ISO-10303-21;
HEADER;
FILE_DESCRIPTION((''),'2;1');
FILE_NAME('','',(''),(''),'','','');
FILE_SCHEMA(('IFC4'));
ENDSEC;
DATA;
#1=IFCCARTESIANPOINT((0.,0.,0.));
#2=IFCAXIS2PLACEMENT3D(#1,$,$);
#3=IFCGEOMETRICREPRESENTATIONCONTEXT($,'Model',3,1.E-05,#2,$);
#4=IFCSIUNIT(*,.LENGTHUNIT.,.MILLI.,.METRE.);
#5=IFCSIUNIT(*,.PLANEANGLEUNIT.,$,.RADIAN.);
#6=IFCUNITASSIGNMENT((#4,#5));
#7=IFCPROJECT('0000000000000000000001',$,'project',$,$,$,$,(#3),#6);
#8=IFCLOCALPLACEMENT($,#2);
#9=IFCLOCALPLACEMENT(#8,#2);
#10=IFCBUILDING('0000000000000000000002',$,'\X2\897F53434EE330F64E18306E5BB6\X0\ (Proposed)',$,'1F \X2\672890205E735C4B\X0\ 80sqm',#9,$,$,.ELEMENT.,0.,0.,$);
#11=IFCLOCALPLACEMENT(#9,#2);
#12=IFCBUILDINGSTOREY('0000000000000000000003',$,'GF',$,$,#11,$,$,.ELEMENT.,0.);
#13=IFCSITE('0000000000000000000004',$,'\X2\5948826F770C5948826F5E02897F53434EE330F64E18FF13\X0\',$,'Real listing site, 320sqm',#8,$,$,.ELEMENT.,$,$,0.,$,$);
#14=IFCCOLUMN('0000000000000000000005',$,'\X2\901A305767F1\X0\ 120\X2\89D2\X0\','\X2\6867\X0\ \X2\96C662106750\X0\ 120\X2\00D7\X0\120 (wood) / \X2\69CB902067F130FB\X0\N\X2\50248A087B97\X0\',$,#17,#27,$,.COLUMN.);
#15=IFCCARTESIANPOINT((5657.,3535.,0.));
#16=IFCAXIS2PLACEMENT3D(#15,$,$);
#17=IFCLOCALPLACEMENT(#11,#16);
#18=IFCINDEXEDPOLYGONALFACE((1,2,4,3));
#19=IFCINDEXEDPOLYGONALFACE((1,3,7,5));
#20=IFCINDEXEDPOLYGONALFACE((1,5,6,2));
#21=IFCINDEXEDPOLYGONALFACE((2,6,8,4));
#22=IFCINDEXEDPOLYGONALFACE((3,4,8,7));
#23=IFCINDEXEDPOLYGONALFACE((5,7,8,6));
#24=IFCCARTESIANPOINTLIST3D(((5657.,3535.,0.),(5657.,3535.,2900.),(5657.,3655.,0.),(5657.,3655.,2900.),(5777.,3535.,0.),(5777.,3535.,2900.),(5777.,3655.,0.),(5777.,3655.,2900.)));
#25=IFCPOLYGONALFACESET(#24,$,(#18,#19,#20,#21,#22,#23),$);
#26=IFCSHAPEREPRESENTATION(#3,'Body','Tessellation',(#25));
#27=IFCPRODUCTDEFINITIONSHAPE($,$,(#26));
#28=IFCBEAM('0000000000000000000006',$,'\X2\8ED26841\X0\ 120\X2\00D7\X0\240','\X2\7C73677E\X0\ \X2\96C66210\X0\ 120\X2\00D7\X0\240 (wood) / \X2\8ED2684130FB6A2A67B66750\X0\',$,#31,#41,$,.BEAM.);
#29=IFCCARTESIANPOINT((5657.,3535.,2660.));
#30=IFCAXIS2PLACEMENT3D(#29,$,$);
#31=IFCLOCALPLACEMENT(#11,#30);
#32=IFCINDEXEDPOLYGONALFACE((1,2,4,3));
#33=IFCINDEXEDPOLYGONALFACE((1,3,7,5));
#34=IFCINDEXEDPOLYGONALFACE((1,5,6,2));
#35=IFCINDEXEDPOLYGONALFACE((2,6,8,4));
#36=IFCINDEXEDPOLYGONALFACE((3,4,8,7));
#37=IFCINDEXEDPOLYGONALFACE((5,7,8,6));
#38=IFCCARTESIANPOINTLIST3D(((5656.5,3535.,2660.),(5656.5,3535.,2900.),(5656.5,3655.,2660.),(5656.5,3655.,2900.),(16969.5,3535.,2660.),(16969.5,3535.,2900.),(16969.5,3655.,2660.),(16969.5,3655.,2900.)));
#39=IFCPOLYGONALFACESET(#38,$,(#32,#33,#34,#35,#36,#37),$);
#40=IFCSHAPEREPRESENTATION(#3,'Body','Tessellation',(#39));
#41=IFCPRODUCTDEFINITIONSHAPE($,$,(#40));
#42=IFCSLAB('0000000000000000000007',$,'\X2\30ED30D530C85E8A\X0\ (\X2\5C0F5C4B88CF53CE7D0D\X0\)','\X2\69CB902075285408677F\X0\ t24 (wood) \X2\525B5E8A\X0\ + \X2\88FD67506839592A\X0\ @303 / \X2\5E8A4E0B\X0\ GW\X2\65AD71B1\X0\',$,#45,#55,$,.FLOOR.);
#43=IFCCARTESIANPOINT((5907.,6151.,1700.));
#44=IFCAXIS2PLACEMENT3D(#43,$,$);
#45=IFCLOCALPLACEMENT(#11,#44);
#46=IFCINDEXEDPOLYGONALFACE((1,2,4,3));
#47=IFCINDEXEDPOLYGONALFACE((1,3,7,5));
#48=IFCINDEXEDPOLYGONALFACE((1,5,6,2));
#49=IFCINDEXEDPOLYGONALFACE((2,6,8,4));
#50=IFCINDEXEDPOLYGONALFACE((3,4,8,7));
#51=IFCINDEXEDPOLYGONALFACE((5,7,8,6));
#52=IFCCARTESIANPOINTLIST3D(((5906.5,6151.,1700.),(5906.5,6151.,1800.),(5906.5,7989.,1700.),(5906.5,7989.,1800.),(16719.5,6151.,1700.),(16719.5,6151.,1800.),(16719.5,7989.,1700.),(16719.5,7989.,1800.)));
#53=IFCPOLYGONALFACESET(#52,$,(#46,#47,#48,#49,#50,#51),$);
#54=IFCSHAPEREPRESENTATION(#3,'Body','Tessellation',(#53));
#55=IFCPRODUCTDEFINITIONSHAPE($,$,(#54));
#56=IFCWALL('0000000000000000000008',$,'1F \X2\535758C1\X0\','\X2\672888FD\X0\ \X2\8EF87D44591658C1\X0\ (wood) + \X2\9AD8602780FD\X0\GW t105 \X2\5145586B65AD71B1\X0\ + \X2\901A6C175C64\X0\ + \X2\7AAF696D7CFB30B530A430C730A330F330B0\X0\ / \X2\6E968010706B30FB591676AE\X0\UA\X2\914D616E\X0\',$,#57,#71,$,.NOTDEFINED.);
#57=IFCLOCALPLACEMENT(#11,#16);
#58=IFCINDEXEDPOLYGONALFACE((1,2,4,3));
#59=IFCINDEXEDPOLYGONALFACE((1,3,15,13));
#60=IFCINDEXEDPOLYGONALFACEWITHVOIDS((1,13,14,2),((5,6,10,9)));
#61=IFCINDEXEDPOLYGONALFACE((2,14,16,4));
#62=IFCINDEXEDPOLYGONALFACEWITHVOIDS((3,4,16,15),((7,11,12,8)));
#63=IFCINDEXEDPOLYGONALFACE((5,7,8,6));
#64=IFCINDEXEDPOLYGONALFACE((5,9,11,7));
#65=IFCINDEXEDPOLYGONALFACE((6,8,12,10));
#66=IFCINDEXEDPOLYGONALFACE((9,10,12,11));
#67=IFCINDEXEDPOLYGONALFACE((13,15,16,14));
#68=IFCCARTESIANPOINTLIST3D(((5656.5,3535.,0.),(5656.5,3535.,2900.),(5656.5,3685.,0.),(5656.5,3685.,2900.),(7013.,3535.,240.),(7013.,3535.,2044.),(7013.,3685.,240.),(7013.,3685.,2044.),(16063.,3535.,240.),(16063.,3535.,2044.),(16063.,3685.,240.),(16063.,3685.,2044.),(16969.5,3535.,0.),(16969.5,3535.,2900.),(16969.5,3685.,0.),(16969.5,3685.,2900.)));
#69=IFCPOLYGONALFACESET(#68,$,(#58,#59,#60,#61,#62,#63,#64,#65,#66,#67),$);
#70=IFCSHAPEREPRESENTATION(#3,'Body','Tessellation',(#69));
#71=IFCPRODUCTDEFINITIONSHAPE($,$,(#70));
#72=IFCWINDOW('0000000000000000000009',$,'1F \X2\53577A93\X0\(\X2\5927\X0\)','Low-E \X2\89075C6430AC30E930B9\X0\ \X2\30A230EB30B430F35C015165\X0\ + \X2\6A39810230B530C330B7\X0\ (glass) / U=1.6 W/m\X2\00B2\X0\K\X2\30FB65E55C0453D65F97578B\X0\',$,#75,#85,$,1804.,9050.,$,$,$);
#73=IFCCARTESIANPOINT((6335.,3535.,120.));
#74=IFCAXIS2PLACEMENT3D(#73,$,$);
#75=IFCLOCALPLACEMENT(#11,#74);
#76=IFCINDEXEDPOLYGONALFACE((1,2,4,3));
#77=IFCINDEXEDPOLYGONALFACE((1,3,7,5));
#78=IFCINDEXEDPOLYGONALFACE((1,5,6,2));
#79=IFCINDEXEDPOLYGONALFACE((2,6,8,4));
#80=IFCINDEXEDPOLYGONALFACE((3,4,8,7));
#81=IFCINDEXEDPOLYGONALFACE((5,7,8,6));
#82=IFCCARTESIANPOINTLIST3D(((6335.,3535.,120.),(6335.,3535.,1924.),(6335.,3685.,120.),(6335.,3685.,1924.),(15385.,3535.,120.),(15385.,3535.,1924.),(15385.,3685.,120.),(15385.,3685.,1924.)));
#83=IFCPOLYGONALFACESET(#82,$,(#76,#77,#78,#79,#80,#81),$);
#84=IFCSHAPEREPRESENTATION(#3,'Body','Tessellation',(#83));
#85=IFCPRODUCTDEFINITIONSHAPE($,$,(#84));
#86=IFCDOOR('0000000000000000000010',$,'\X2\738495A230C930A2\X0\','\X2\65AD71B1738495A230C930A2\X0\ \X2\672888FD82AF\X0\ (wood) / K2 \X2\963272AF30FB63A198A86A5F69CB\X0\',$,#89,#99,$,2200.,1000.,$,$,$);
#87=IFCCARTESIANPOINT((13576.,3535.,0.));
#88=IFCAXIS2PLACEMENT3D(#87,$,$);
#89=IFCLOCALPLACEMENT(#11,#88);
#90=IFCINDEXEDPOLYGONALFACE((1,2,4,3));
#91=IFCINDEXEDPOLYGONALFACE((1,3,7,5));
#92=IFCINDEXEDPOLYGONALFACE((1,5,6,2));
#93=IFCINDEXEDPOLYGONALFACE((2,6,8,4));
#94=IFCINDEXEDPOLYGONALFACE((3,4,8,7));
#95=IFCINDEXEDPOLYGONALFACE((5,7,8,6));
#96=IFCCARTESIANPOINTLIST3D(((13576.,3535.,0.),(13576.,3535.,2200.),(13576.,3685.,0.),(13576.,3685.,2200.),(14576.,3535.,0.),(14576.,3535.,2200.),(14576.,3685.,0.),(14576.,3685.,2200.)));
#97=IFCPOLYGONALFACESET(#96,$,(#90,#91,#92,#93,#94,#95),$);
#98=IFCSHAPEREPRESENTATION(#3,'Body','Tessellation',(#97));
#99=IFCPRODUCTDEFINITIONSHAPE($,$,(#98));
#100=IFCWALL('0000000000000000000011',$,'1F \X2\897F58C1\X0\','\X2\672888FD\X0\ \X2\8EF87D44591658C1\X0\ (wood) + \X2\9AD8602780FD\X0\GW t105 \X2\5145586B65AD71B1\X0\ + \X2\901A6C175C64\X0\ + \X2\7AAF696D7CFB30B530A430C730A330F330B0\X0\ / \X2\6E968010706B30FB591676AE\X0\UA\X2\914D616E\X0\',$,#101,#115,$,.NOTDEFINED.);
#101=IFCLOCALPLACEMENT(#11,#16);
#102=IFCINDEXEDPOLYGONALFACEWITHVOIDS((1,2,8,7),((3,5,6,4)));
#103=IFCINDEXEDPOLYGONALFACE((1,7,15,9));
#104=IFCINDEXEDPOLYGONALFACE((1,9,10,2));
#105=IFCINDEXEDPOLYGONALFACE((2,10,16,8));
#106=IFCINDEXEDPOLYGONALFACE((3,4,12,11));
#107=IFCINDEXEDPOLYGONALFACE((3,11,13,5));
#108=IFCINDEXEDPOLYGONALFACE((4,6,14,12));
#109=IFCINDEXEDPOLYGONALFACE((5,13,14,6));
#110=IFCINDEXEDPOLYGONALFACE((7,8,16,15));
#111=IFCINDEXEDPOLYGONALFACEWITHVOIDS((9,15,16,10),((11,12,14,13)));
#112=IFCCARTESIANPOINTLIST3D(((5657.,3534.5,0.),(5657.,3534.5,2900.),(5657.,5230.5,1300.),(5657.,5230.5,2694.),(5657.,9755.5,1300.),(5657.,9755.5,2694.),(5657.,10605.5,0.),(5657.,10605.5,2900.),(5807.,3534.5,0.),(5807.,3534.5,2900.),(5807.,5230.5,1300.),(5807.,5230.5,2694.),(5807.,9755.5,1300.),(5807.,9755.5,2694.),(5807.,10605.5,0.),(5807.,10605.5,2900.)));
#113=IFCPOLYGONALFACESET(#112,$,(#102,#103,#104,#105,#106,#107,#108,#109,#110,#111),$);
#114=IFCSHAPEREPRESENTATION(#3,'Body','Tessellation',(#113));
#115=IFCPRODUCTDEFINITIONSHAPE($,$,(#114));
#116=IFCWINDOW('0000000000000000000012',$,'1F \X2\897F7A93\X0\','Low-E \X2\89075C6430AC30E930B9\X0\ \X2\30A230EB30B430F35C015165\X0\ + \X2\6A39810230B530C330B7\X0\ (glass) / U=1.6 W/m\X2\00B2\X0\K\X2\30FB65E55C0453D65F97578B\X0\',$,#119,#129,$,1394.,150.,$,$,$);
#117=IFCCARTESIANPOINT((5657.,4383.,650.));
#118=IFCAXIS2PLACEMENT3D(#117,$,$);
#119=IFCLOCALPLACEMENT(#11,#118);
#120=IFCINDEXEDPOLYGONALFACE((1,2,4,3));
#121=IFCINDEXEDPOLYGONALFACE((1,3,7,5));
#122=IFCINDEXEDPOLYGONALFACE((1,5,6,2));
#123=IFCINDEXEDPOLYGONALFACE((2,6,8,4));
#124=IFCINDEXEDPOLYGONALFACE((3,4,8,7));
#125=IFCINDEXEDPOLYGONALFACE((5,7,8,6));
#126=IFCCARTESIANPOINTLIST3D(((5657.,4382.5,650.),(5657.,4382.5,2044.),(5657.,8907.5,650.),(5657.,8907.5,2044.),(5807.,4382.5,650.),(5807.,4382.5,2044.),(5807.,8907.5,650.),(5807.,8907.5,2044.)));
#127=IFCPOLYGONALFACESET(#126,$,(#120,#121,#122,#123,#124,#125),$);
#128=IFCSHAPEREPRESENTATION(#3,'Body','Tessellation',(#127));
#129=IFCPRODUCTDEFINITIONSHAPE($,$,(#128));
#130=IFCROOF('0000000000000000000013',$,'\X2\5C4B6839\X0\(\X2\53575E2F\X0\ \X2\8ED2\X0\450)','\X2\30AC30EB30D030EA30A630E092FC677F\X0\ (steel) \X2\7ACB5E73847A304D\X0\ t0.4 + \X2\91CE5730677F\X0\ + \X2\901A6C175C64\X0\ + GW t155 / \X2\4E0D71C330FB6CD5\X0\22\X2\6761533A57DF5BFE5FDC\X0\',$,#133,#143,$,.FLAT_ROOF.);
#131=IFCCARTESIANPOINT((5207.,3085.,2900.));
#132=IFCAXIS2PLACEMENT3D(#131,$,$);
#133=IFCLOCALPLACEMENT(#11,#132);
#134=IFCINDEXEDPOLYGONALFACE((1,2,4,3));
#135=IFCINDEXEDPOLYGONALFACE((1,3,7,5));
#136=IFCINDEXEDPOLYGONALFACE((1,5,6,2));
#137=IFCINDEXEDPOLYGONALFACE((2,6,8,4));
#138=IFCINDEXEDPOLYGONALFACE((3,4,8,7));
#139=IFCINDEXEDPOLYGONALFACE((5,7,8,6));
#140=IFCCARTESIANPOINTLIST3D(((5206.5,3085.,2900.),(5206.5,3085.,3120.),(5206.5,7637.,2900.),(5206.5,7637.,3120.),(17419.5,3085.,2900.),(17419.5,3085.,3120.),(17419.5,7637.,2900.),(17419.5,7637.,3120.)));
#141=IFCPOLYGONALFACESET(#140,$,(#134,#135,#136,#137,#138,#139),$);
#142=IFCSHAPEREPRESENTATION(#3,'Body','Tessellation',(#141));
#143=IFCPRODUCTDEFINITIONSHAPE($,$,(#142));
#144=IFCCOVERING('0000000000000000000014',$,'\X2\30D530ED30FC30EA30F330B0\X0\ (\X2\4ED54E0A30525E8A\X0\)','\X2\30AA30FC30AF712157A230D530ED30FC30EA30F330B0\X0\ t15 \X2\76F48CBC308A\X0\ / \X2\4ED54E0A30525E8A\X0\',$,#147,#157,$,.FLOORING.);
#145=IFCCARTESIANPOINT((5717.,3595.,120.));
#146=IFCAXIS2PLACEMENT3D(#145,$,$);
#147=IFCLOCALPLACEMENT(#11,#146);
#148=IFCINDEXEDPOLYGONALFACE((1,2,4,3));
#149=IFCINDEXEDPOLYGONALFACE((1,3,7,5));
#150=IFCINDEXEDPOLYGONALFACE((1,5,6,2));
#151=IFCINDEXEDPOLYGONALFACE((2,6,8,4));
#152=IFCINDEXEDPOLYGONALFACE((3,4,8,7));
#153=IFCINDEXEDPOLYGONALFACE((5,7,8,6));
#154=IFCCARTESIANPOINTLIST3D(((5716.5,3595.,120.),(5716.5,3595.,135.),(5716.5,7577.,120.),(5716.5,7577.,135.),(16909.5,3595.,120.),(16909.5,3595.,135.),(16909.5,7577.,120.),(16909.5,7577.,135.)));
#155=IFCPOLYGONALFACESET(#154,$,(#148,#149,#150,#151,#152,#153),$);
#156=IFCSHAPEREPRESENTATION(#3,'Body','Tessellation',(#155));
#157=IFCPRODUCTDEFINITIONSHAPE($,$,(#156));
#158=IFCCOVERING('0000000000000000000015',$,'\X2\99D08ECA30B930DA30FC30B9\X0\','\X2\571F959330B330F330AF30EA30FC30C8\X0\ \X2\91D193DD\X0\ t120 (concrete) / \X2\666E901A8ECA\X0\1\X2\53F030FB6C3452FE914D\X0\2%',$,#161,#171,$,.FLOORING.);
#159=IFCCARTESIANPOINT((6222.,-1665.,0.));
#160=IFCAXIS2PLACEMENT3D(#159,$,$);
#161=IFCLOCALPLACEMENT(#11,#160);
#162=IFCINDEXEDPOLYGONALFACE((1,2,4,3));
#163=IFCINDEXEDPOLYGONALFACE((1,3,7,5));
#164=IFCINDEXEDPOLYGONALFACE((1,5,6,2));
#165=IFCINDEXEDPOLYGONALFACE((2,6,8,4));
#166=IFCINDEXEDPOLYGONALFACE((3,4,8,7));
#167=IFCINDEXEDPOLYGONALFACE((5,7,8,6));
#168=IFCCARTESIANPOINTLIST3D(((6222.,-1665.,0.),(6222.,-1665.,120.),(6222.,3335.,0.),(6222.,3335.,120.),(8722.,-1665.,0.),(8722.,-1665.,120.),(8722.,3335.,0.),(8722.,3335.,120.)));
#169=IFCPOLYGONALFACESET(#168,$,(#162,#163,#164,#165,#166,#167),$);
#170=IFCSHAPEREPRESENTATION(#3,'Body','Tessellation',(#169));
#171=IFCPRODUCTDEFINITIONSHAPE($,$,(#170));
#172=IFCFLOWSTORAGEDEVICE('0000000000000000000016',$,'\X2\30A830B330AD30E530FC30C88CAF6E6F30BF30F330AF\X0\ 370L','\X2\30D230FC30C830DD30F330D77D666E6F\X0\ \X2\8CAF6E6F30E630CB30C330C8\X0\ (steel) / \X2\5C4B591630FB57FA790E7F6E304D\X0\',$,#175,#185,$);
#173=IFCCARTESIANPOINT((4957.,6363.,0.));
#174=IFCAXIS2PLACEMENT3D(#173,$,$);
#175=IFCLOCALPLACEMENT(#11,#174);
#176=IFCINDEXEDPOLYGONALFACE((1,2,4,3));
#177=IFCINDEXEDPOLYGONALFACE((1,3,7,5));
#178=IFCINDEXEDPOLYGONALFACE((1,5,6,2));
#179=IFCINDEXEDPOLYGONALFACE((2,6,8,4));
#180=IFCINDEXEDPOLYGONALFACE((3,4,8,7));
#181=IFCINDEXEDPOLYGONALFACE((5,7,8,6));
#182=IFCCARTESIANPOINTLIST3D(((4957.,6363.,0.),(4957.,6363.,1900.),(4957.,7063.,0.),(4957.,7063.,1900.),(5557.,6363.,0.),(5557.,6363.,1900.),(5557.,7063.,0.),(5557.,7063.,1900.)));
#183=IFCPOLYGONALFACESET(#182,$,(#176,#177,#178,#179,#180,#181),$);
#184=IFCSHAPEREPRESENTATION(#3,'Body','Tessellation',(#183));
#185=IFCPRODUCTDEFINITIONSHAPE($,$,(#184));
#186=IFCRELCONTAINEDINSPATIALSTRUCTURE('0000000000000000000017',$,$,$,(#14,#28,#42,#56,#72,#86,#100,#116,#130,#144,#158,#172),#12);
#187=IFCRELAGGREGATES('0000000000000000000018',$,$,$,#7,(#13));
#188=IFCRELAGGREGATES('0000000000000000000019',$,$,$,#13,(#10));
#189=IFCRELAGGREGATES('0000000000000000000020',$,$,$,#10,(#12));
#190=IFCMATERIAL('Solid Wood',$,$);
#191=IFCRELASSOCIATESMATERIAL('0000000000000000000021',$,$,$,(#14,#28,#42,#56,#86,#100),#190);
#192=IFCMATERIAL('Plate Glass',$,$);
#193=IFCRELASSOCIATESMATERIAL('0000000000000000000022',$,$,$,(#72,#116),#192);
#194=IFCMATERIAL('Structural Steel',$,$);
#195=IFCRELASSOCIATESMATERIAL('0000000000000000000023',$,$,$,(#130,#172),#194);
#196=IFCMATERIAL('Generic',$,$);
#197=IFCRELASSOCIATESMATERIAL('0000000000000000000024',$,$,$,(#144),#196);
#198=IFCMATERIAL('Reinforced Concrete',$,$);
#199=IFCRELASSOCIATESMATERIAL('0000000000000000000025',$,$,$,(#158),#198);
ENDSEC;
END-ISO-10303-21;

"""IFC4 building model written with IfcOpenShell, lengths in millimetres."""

from ifc_helpers import new_model, si_unit, frame, frame_2d, origin, place, context, project, spatial, rectangle, extrude, material, element, fill, save


model = new_model("IFC4")

# Units and contexts
model_context = context("Model", 3, precision=1e-05, world=origin())
ifc_project = project(units=[si_unit("LENGTHUNIT", "METRE", prefix="MILLI"), si_unit("PLANEANGLEUNIT", "RADIAN")], contexts=[model_context])

# Site, building, storey
site_placement = place(None, origin())
site = spatial("IfcSite", under=ifc_project, at=site_placement, Name="奈良県奈良市西千代ヶ丘３", ObjectType="Real listing site, 320sqm", CompositionType="ELEMENT", RefElevation=0.0)
building_placement = place(site_placement, origin())
building = spatial("IfcBuilding", under=site, at=building_placement, Name="西千代ヶ丘の家 (Proposed)", ObjectType="1F 木造平屋 80sqm", CompositionType="ELEMENT", ElevationOfRefHeight=0.0, ElevationOfTerrain=0.0)
storey_placement = place(building_placement, origin())
storey = spatial("IfcBuildingStorey", under=building, at=storey_placement, Name="GF", CompositionType="ELEMENT", Elevation=0.0)

# Column
ifc_material_1 = material(Name="Solid Wood")
column_1_placement = place(storey_placement, frame((5657.0, 3535.0, 0.0)))
element("IfcColumn", 1, at=column_1_placement, inside=storey, material=ifc_material_1, Name="通し柱 120角", Description="桧 集成材 120×120 (wood) / 構造柱・N値計算", PredefinedType="COLUMN", context=model_context, shape_type="SweptSolid", body=[
    extrude(rectangle(XDim=120.0, YDim=120.0, at=frame_2d((60.0, 60.0))), frame((5657.0, 3535.0, 0.0)), (0.0, 0.0, 1.0), 2900.0),
])

# Beam
beam_1_placement = place(storey_placement, frame((5657.0, 3535.0, 2660.0)))
element("IfcBeam", 2, at=beam_1_placement, inside=storey, material=ifc_material_1, Name="軒桁 120×240", Description="米松 集成 120×240 (wood) / 軒桁・横架材", PredefinedType="BEAM", context=model_context, shape_type="SweptSolid", body=[
    extrude(rectangle(XDim=11313.0, YDim=120.0, at=frame_2d((5656.0, 60.0))), frame((5657.0, 3535.0, 2660.0)), (0.0, 0.0, 1.0), 240.0),
])

# Slab
ifc_material_2 = material(Name="Reinforced Concrete")
slab_1_placement = place(storey_placement, frame((5907.0, 6151.0, 1700.0)))
element("IfcSlab", 3, at=slab_1_placement, inside=storey, material=ifc_material_1, Name="ロフト床 (小屋裏収納)", Description="構造用合板 t24 (wood) 剛床 + 製材根太 @303 / 床下 GW断熱", PredefinedType="FLOOR", context=model_context, shape_type="SweptSolid", body=[
    extrude(rectangle(XDim=10813.0, YDim=1838.0, at=frame_2d((5406.0, 919.0))), frame((5907.0, 6151.0, 1700.0)), (0.0, 0.0, 1.0), 100.0),
])

# Wall, openings, window, door
wall_1_placement = place(storey_placement, frame((5657.0, 3535.0, 0.0)))
wall_1 = element("IfcWall", 4, at=wall_1_placement, inside=storey, material=ifc_material_1, Name="1F 南壁", Description="木製 軸組外壁 (wood) + 高性能GW t105 充填断熱 + 通気層 + 窯業系サイディング / 準耐火・外皮UA配慮", PredefinedType="NOTDEFINED", context=model_context, shape_type="SweptSolid", body=[
    extrude(rectangle(XDim=11313.0, YDim=150.0, at=frame_2d((5656.0, 75.0))), frame((5657.0, 3535.0, 0.0)), (0.0, 0.0, 1.0), 2900.0),
])
opening_1_placement = place(storey_placement, frame((6335.0, 3535.0, 120.0)))
opening_1 = element("IfcOpeningElement", 5, at=opening_1_placement, cuts=wall_1, PredefinedType="NOTDEFINED", context=model_context, shape_type="SweptSolid", body=[
    extrude(rectangle(XDim=9050.0, YDim=150.0, at=frame_2d((4525.0, 75.0))), frame((6335.0, 3535.0, 120.0)), (0.0, 0.0, 1.0), 1804.0),
])
opening_2_placement = place(storey_placement, frame((13576.0, 3535.0, 0.0)))
opening_2 = element("IfcOpeningElement", 6, at=opening_2_placement, cuts=wall_1, PredefinedType="NOTDEFINED", context=model_context, shape_type="SweptSolid", body=[
    extrude(rectangle(XDim=1000.0, YDim=150.0, at=frame_2d((500.0, 75.0))), frame((13576.0, 3535.0, 0.0)), (0.0, 0.0, 1.0), 2200.0),
])
ifc_material_3 = material(Name="Plate Glass")
window_1_placement = place(storey_placement, frame((6335.0, 3535.0, 120.0)))
window_1 = element("IfcWindow", 7, at=window_1_placement, inside=storey, material=ifc_material_3, Name="1F 南窓(大)", Description="Low-E 複層ガラス アルゴン封入 + 樹脂サッシ (glass) / U=1.6 W/m²K・日射取得型", OverallHeight=1804.0, OverallWidth=9050.0, context=model_context, shape_type="SweptSolid", body=[
    extrude(rectangle(XDim=9050.0, YDim=150.0, at=frame_2d((4525.0, 75.0))), frame((6335.0, 3535.0, 120.0)), (0.0, 0.0, 1.0), 1804.0),
])
fill(opening_1, window_1)
door_placement = place(storey_placement, frame((13576.0, 3535.0, 0.0)))
door = element("IfcDoor", 8, at=door_placement, inside=storey, material=ifc_material_1, Name="玄関ドア", Description="断熱玄関ドア 木製芯 (wood) / K2 防犯・採風機構", OverallHeight=2200.0, OverallWidth=1000.0, context=model_context, shape_type="SweptSolid", body=[
    extrude(rectangle(XDim=1000.0, YDim=150.0, at=frame_2d((500.0, 75.0))), frame((13576.0, 3535.0, 0.0)), (0.0, 0.0, 1.0), 2200.0),
])
fill(opening_2, door)

# Wall, opening, window
wall_2_placement = place(storey_placement, frame((5657.0, 3535.0, 0.0)))
wall_2 = element("IfcWall", 9, at=wall_2_placement, inside=storey, material=ifc_material_1, Name="1F 西壁", Description="木製 軸組外壁 (wood) + 高性能GW t105 充填断熱 + 通気層 + 窯業系サイディング / 準耐火・外皮UA配慮", PredefinedType="NOTDEFINED", context=model_context, shape_type="SweptSolid", body=[
    extrude(rectangle(XDim=150.0, YDim=7071.0, at=frame_2d((75.0, 3535.0))), frame((5657.0, 3535.0, 0.0)), (0.0, 0.0, 1.0), 2900.0),
])
opening_3_placement = place(storey_placement, frame((5657.0, 4383.0, 650.0)))
opening_3 = element("IfcOpeningElement", 10, at=opening_3_placement, cuts=wall_2, PredefinedType="NOTDEFINED", context=model_context, shape_type="SweptSolid", body=[
    extrude(rectangle(XDim=150.0, YDim=4525.0, at=frame_2d((75.0, 2262.0))), frame((5657.0, 4383.0, 650.0)), (0.0, 0.0, 1.0), 1394.0),
])
window_2_placement = place(storey_placement, frame((5657.0, 4383.0, 650.0)))
window_2 = element("IfcWindow", 11, at=window_2_placement, inside=storey, material=ifc_material_3, Name="1F 西窓", Description="Low-E 複層ガラス アルゴン封入 + 樹脂サッシ (glass) / U=1.6 W/m²K・日射取得型", OverallHeight=1394.0, OverallWidth=150.0, context=model_context, shape_type="SweptSolid", body=[
    extrude(rectangle(XDim=150.0, YDim=4525.0, at=frame_2d((75.0, 2262.0))), frame((5657.0, 4383.0, 650.0)), (0.0, 0.0, 1.0), 1394.0),
])
fill(opening_3, window_2)

# Roof
ifc_material_4 = material(Name="Structural Steel")
roof_placement = place(storey_placement, frame((5207.0, 3085.0, 2900.0)))
element("IfcRoof", 12, at=roof_placement, inside=storey, material=ifc_material_4, Name="屋根(南帯 軒450)", Description="ガルバリウム鋼板 (steel) 立平葺き t0.4 + 野地板 + 通気層 + GW t155 / 不燃・法22条区域対応", PredefinedType="FLAT_ROOF", context=model_context, shape_type="SweptSolid", body=[
    extrude(rectangle(XDim=12213.0, YDim=4552.0, at=frame_2d((6106.0, 2276.0))), frame((5207.0, 3085.0, 2900.0)), (0.0, 0.0, 1.0), 220.0),
])

# Coverings
ifc_material_5 = material(Name="Generic")
covering_1_placement = place(storey_placement, frame((5717.0, 3595.0, 120.0)))
element("IfcCovering", 13, at=covering_1_placement, inside=storey, material=ifc_material_5, Name="フローリング (仕上げ床)", Description="オーク無垢フローリング t15 直貼り / 仕上げ床", PredefinedType="FLOORING", context=model_context, shape_type="SweptSolid", body=[
    extrude(rectangle(XDim=11193.0, YDim=3982.0, at=frame_2d((5596.0, 1991.0))), frame((5717.0, 3595.0, 120.0)), (0.0, 0.0, 1.0), 15.0),
])
covering_2_placement = place(storey_placement, frame((6222.0, -1665.0, 0.0)))
element("IfcCovering", 14, at=covering_2_placement, inside=storey, material=ifc_material_2, Name="駐車スペース", Description="土間コンクリート 金鏝 t120 (concrete) / 普通車1台・水勾配2%", PredefinedType="FLOORING", context=model_context, shape_type="SweptSolid", body=[
    extrude(rectangle(XDim=2500.0, YDim=5000.0, at=frame_2d((1250.0, 2500.0))), frame((6222.0, -1665.0, 0.0)), (0.0, 0.0, 1.0), 120.0),
])

# Flow storage device
flow_storage_device_placement = place(storey_placement, frame((4957.0, 6363.0, 0.0)))
element("IfcFlowStorageDevice", 15, at=flow_storage_device_placement, inside=storey, material=ifc_material_4, Name="エコキュート貯湯タンク 370L", Description="ヒートポンプ給湯 貯湯ユニット (steel) / 屋外・基礎置き", context=model_context, shape_type="SweptSolid", body=[
    extrude(rectangle(XDim=600.0, YDim=700.0, at=frame_2d((300.0, 350.0))), frame((4957.0, 6363.0, 0.0)), (0.0, 0.0, 1.0), 1900.0),
])

save(model, "model.ifc")
